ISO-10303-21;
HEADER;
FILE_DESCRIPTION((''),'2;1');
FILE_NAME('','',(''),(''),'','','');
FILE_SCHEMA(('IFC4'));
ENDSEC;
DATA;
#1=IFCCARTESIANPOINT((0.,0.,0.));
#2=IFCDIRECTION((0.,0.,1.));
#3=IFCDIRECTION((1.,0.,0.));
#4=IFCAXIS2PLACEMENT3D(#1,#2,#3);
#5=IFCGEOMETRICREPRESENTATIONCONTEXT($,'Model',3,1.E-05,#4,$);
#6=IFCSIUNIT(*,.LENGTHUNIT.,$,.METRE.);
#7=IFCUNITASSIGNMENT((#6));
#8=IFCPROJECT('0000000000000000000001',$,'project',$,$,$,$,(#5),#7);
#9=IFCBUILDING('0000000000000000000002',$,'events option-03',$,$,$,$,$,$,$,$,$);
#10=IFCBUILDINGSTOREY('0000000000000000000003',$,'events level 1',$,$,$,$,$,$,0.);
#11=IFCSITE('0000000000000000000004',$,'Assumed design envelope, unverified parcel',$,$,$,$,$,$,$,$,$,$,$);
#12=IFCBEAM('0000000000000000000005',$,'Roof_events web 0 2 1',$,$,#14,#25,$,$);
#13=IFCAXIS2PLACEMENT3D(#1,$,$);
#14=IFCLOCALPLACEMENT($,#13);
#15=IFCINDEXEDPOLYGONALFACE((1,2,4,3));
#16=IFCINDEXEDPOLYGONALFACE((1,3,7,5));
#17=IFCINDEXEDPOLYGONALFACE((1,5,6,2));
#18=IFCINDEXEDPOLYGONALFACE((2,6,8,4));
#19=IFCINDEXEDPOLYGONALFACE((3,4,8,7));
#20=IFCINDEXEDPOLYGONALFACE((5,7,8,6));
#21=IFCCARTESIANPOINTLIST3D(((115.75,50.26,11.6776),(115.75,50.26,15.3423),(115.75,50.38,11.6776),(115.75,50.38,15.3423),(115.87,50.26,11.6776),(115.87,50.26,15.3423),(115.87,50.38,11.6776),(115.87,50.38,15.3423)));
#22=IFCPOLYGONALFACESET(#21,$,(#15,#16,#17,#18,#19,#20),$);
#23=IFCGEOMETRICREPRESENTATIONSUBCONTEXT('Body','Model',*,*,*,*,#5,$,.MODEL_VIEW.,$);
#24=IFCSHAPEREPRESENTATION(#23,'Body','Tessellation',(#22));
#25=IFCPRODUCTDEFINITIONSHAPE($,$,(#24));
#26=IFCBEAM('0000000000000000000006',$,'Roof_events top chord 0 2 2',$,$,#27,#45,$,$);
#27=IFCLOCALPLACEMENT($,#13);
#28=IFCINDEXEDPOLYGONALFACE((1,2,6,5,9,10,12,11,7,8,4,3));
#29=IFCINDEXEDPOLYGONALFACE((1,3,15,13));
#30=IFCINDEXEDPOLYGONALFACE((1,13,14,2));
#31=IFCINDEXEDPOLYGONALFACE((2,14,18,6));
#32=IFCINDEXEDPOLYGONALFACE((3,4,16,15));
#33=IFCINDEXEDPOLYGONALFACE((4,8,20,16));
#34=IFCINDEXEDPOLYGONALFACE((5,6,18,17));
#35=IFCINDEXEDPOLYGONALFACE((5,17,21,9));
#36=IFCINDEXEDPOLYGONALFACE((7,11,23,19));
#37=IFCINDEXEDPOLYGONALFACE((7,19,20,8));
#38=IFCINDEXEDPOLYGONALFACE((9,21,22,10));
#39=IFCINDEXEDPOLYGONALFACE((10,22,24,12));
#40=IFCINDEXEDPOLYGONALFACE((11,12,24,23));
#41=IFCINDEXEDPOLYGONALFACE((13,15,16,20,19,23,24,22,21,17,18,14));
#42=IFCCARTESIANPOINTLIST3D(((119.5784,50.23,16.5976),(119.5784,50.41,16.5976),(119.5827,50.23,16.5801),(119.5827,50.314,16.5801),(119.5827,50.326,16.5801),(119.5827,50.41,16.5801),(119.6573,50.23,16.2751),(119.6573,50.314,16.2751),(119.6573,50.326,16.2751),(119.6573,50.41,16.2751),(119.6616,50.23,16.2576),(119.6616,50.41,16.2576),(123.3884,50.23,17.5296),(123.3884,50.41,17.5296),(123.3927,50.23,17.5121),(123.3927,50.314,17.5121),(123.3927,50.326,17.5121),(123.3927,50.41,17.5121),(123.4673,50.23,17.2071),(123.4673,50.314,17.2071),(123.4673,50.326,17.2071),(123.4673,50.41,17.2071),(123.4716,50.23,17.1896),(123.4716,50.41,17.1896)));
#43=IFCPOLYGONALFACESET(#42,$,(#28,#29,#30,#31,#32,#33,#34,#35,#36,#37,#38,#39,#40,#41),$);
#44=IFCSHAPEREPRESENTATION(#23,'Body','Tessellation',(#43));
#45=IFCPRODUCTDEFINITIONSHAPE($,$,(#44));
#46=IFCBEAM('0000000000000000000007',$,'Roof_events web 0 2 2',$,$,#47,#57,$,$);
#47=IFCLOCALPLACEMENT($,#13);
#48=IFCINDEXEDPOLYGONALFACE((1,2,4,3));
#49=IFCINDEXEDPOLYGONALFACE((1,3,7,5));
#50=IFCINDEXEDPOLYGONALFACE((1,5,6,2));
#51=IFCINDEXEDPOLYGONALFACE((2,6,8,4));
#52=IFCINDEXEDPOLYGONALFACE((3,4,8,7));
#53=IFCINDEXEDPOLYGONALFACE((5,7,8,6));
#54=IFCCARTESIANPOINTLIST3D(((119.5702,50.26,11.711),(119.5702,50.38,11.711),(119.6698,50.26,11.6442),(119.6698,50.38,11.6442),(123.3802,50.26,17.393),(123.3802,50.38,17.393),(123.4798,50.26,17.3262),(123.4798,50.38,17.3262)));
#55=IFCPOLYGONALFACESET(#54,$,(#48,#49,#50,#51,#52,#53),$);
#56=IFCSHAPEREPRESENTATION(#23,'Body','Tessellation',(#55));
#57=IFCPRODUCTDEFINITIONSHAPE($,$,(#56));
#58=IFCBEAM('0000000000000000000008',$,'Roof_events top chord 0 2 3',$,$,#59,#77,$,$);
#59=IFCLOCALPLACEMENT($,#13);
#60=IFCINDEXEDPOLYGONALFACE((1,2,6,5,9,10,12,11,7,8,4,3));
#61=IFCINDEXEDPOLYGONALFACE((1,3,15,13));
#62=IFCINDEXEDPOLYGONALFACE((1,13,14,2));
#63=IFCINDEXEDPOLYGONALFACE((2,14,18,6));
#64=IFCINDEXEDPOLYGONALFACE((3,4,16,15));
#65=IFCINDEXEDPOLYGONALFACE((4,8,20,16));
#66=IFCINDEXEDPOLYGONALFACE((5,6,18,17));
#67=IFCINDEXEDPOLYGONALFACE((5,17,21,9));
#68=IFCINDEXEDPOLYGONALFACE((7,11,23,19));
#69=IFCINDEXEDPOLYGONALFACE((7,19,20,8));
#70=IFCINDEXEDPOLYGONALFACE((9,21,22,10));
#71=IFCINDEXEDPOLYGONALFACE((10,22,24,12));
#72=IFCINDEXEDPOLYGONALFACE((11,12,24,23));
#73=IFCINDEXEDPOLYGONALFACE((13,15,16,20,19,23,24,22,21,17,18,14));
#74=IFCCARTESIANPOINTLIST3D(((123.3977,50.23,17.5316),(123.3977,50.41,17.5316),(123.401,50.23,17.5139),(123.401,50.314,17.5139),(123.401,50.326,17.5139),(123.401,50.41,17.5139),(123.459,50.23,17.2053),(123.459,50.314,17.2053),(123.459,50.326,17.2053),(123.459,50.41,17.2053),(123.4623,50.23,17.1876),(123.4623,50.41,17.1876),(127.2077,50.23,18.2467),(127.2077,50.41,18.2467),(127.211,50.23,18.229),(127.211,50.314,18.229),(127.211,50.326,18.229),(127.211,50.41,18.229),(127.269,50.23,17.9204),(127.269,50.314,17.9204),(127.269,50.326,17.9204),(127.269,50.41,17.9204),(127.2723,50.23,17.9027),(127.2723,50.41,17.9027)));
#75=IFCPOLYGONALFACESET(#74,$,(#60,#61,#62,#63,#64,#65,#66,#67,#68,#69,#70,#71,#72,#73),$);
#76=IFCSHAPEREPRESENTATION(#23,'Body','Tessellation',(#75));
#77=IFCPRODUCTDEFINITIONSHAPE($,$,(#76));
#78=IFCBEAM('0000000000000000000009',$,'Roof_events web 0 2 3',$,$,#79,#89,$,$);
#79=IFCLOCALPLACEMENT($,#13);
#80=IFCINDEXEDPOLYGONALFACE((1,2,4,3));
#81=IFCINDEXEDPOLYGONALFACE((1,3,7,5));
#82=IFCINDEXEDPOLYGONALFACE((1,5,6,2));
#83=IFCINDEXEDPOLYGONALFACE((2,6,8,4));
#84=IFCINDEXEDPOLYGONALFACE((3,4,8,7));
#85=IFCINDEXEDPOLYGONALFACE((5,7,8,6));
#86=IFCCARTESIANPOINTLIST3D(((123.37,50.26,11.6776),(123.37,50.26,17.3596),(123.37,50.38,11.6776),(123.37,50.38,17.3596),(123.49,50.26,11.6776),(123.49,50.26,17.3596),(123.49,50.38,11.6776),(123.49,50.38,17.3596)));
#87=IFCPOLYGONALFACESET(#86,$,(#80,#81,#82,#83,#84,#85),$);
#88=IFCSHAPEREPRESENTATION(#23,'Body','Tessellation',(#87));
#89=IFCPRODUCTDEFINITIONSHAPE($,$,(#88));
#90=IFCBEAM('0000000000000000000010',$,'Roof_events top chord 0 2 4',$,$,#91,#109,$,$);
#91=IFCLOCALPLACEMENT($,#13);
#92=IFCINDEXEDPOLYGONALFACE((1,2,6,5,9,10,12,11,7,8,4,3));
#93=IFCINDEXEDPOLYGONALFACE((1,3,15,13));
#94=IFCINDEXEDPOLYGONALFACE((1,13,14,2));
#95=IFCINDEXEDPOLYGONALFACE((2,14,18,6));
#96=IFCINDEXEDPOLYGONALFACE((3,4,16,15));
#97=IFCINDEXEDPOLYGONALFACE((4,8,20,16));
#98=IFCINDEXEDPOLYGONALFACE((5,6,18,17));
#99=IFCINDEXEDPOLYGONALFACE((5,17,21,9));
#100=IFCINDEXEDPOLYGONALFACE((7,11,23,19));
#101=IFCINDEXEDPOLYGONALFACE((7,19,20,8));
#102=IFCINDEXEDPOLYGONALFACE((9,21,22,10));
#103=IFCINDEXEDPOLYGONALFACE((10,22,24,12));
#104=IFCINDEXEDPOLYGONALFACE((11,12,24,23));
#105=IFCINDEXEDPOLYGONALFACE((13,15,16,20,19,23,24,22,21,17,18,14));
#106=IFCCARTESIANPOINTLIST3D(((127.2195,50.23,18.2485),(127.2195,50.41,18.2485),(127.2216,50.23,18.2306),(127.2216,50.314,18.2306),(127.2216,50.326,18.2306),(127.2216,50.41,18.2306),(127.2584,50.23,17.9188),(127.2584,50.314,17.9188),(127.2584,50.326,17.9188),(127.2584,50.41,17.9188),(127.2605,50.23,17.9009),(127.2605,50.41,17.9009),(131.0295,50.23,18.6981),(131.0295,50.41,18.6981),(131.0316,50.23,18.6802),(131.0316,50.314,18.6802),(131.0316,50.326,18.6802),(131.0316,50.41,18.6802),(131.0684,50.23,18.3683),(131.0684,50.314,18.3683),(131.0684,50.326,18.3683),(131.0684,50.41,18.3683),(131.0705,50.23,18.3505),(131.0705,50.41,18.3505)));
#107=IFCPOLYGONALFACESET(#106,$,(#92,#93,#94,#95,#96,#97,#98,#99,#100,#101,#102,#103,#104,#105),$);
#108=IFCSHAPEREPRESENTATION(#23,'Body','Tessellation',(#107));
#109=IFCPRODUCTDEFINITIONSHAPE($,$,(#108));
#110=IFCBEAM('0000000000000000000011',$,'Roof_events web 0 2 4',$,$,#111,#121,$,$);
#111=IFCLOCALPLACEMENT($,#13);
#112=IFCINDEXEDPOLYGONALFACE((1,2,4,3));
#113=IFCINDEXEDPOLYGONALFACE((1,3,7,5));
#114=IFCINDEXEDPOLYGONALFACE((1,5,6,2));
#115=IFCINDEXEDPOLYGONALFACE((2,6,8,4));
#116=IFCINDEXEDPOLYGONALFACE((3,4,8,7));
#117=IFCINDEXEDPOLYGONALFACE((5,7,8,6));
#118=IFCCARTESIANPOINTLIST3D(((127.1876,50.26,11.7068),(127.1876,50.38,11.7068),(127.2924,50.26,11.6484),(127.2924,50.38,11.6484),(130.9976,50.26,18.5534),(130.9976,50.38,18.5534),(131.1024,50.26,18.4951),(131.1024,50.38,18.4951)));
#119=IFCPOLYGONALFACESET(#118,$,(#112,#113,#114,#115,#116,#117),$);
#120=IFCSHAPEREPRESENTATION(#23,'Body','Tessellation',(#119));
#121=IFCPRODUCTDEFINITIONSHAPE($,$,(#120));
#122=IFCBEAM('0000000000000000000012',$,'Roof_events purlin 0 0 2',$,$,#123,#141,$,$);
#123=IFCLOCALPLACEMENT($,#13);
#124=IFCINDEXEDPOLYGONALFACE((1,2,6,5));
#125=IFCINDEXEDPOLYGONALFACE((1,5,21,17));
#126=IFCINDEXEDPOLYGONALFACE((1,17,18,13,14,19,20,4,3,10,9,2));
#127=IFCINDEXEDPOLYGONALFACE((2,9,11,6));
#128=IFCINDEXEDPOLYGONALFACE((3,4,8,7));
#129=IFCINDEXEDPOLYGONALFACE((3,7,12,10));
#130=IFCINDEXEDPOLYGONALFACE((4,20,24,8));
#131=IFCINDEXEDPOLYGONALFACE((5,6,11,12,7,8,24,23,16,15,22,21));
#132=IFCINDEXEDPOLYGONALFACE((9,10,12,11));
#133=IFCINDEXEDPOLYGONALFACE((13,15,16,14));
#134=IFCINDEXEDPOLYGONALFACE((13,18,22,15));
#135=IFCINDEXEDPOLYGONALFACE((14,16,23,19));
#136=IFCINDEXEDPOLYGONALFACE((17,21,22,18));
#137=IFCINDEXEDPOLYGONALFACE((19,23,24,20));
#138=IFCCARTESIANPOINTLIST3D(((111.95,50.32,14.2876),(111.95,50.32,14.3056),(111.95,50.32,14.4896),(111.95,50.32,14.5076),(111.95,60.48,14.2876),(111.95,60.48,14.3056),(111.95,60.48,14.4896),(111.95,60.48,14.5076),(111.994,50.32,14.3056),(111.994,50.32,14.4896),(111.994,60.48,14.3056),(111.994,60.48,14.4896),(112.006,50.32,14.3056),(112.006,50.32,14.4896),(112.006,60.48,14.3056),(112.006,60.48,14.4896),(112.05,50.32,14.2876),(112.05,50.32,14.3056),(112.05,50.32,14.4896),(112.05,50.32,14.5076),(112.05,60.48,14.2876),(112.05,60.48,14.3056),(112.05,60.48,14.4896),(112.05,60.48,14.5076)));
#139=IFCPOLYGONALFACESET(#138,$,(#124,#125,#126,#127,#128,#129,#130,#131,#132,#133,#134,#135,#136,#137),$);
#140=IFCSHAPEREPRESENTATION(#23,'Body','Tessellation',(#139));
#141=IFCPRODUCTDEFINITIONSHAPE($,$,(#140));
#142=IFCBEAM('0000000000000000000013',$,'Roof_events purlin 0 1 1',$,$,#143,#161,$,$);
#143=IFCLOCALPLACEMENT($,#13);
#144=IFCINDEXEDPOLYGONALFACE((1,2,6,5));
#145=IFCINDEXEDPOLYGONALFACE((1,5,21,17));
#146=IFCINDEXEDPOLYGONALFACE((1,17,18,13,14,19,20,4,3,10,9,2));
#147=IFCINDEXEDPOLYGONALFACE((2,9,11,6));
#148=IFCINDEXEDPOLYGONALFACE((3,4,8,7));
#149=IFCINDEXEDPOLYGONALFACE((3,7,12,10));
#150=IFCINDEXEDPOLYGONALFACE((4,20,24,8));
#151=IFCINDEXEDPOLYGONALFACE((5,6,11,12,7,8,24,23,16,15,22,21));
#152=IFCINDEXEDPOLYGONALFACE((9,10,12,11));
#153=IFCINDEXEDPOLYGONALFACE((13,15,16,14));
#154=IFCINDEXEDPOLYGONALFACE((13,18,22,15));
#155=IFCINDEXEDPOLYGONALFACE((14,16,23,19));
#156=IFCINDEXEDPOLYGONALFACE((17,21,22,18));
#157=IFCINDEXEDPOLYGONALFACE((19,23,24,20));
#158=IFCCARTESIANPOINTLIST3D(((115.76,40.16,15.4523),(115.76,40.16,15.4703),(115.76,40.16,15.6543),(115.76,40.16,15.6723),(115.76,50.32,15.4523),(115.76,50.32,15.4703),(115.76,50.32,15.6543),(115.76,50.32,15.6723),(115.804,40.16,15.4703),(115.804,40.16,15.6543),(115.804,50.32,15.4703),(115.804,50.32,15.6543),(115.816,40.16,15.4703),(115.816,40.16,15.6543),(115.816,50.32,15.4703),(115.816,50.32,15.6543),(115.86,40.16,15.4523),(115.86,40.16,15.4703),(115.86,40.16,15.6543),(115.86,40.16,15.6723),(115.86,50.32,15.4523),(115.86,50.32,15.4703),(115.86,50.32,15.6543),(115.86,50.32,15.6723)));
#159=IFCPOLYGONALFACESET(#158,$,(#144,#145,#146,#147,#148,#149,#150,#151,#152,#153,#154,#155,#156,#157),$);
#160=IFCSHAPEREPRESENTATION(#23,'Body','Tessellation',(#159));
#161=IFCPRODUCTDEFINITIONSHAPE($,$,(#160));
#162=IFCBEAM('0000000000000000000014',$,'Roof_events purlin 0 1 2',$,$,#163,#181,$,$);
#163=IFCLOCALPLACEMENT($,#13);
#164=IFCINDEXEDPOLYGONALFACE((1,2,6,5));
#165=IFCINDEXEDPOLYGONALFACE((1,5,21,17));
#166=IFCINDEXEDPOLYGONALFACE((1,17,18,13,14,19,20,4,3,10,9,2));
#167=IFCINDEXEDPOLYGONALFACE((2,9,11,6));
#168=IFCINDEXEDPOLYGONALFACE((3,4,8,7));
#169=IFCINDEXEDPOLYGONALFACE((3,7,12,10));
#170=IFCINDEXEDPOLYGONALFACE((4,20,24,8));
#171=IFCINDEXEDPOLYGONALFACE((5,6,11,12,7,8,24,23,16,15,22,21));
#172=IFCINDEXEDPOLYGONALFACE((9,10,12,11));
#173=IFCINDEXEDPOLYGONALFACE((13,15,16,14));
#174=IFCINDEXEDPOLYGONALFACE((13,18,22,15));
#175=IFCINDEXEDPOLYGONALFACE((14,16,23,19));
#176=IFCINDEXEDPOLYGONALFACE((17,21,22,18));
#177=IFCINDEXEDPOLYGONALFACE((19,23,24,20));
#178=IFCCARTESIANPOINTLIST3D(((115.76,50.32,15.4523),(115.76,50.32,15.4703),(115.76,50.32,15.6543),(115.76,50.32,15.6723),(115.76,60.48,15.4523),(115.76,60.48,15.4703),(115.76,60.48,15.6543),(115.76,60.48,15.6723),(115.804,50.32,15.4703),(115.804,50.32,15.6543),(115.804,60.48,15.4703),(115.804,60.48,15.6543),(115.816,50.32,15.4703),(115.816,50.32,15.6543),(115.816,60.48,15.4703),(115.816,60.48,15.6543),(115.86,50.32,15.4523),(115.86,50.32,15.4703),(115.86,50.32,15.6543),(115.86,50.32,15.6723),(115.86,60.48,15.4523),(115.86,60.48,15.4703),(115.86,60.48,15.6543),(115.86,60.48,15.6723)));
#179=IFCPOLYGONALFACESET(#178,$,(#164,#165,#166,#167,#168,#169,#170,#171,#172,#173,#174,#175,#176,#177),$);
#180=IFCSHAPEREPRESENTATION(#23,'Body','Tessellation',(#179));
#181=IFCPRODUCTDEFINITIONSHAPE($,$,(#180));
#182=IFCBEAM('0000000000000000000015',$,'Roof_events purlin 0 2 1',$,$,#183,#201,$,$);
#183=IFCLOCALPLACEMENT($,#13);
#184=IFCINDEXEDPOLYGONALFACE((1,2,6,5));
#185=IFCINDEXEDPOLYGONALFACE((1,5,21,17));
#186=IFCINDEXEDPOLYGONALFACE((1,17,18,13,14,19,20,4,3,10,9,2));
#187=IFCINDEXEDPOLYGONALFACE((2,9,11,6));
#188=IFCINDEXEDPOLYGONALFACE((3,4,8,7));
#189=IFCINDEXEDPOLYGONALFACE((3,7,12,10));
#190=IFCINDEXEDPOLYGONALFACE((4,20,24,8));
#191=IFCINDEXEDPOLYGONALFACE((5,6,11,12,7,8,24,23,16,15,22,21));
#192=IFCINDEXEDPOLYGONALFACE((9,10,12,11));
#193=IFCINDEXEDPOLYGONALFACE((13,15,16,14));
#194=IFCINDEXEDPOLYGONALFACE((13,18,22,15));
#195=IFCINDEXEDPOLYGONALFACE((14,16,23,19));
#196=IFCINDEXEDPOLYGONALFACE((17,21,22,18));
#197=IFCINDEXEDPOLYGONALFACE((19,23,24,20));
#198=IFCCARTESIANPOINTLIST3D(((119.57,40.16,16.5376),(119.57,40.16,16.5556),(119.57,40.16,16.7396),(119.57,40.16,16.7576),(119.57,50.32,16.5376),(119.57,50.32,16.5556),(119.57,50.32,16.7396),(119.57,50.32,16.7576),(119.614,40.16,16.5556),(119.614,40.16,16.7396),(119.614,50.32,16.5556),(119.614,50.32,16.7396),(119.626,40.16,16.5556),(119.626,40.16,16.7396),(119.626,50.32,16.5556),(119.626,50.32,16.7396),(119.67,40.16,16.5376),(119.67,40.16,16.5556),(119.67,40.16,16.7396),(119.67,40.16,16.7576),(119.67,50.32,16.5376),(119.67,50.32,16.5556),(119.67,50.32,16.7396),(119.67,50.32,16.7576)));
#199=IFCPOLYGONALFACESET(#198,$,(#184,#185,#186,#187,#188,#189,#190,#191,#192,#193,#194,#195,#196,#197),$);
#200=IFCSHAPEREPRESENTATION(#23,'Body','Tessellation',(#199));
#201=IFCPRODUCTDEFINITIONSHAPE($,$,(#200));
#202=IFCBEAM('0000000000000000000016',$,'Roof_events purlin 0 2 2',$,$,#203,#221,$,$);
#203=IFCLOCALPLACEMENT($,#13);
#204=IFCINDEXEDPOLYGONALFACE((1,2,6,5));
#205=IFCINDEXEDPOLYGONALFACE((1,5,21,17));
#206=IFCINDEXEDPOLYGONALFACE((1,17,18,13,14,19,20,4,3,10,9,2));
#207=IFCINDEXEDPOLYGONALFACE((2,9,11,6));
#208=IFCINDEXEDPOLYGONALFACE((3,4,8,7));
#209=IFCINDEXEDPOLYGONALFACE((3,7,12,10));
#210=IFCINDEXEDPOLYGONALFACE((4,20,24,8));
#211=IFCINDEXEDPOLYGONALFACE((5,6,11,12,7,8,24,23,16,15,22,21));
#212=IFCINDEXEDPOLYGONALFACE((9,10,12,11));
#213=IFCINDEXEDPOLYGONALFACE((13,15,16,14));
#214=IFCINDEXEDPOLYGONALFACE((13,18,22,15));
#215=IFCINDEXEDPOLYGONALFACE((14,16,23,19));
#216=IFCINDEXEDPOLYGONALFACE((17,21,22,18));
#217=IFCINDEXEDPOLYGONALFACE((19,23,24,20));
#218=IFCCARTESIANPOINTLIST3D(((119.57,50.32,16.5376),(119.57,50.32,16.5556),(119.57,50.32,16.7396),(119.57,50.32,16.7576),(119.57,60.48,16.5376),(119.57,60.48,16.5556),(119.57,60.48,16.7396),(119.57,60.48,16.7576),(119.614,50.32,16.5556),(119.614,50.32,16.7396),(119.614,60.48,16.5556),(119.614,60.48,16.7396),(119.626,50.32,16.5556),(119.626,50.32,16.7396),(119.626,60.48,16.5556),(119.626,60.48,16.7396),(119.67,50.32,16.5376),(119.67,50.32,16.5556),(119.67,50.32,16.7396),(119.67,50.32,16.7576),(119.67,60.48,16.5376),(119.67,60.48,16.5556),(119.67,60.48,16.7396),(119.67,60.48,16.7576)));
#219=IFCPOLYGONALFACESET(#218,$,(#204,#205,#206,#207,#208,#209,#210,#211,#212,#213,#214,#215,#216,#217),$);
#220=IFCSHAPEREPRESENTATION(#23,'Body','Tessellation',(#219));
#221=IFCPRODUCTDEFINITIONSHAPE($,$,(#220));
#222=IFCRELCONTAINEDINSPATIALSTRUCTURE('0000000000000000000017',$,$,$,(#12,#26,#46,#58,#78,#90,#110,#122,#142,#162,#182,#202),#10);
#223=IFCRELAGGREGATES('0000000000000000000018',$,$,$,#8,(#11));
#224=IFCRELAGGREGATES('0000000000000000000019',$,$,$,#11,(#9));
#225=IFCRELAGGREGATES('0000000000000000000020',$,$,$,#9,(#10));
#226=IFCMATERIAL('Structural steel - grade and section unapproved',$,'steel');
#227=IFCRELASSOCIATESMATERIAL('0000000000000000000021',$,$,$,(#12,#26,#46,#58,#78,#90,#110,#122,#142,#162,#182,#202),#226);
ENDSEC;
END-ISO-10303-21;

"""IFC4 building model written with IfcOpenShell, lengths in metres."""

from ifc_helpers import new_model, si_unit, frame, origin_with_axes, place, context, subcontext, project, spatial, rectangle, i_section, extrude, material, element, save


model = new_model("IFC4")

# Units and contexts
model_context = context("Model", 3, precision=1e-05, world=origin_with_axes())
body_context = subcontext(model_context, "Body", "Model", "MODEL_VIEW")
ifc_project = project(units=[si_unit("LENGTHUNIT", "METRE")], contexts=[model_context])

# Site, building, storey
site = spatial("IfcSite", under=ifc_project, Name="Assumed design envelope, unverified parcel")
building = spatial("IfcBuilding", under=site, Name="events option-03")
storey = spatial("IfcBuildingStorey", under=building, Name="events level 1", Elevation=0.0)

# Shared definitions
ifc_material_1 = material(Name="Structural steel - grade and section unapproved", Category="steel")

# Beams
beam_1_placement = place(None, frame((115.81, 50.32, 11.6776), z_axis=(0.0, 0.0, 1.0), x_axis=(-1.0, 0.0, 0.0)))
element("IfcBeam", 1, at=beam_1_placement, inside=storey, material=ifc_material_1, Name="Roof_events web 0 2 1", context=body_context, shape_type="SweptSolid", body=[
    extrude(rectangle(XDim=0.12, YDim=0.12), origin_with_axes(), (0.0, 0.0, 1.0), 3.6647),
])
beam_2_placement = place(None, frame((119.62, 50.32, 16.4276), z_axis=(0.971361, 0.0, 0.237609), x_axis=(0.0, 1.0, 0.0)))
element("IfcBeam", 2, at=beam_2_placement, inside=storey, material=ifc_material_1, Name="Roof_events top chord 0 2 2", context=body_context, shape_type="SweptSolid", body=[
    extrude(i_section(OverallWidth=0.18, OverallDepth=0.35, WebThickness=0.012, FlangeThickness=0.018, FilletRadius=0.0), origin_with_axes(), (0.0, 0.0, 1.0), 3.9223),
])
beam_3_placement = place(None, frame((119.62, 50.32, 11.6776), z_axis=(0.556926, 0.0, 0.830562), x_axis=(0.0, 1.0, 0.0)))
element("IfcBeam", 3, at=beam_3_placement, inside=storey, material=ifc_material_1, Name="Roof_events web 0 2 2", context=body_context, shape_type="SweptSolid", body=[
    extrude(rectangle(XDim=0.12, YDim=0.12), origin_with_axes(), (0.0, 0.0, 1.0), 6.8411),
])
beam_4_placement = place(None, frame((123.43, 50.32, 17.3596), z_axis=(0.982837, 0.0, 0.184478), x_axis=(0.0, 1.0, 0.0)))
element("IfcBeam", 4, at=beam_4_placement, inside=storey, material=ifc_material_1, Name="Roof_events top chord 0 2 3", context=body_context, shape_type="SweptSolid", body=[
    extrude(i_section(OverallWidth=0.18, OverallDepth=0.35, WebThickness=0.012, FlangeThickness=0.018, FilletRadius=0.0), origin_with_axes(), (0.0, 0.0, 1.0), 3.8765),
])
beam_5_placement = place(None, frame((123.43, 50.32, 11.6776), z_axis=(0.0, 0.0, 1.0), x_axis=(-1.0, 0.0, 0.0)))
element("IfcBeam", 5, at=beam_5_placement, inside=storey, material=ifc_material_1, Name="Roof_events web 0 2 3", context=body_context, shape_type="SweptSolid", body=[
    extrude(rectangle(XDim=0.12, YDim=0.12), origin_with_axes(), (0.0, 0.0, 1.0), 5.682),
])
beam_6_placement = place(None, frame((127.24, 50.32, 18.0747), z_axis=(0.993111, 0.0, 0.117179), x_axis=(0.0, 1.0, 0.0)))
element("IfcBeam", 6, at=beam_6_placement, inside=storey, material=ifc_material_1, Name="Roof_events top chord 0 2 4", context=body_context, shape_type="SweptSolid", body=[
    extrude(i_section(OverallWidth=0.18, OverallDepth=0.35, WebThickness=0.012, FlangeThickness=0.018, FilletRadius=0.0), origin_with_axes(), (0.0, 0.0, 1.0), 3.8364),
])
beam_7_placement = place(None, frame((127.24, 50.32, 11.6776), z_axis=(0.486257, 0.0, 0.873816), x_axis=(0.0, 1.0, 0.0)))
element("IfcBeam", 7, at=beam_7_placement, inside=storey, material=ifc_material_1, Name="Roof_events web 0 2 4", context=body_context, shape_type="SweptSolid", body=[
    extrude(rectangle(XDim=0.12, YDim=0.12), origin_with_axes(), (0.0, 0.0, 1.0), 7.8354),
])
for number, where, z_axis, x_axis, name in (
    (8, (112.0, 50.32, 14.3976), (0.0, 1.0, 0.0), (-1.0, 0.0, 0.0), "Roof_events purlin 0 0 2"),
    (9, (115.81, 40.16, 15.5623), (0.0, 1.0, 0.0), (-1.0, 0.0, 0.0), "Roof_events purlin 0 1 1"),
    (10, (115.81, 50.32, 15.5623), (0.0, 1.0, 0.0), (-1.0, 0.0, 0.0), "Roof_events purlin 0 1 2"),
    (11, (119.62, 40.16, 16.6476), (0.0, 1.0, 0.0), (-1.0, 0.0, 0.0), "Roof_events purlin 0 2 1"),
    (12, (119.62, 50.32, 16.6476), (0.0, 1.0, 0.0), (-1.0, 0.0, 0.0), "Roof_events purlin 0 2 2"),
):
    element("IfcBeam", number, at=place(None, frame(where, z_axis=z_axis, x_axis=x_axis)), inside=storey, material=ifc_material_1, Name=name, context=body_context, shape_type="SweptSolid", body=[
        extrude(i_section(OverallWidth=0.1, OverallDepth=0.22, WebThickness=0.012, FlangeThickness=0.018, FilletRadius=0.0), origin_with_axes(), (0.0, 0.0, 1.0), 10.16),
    ])

save(model, "model.ifc")
